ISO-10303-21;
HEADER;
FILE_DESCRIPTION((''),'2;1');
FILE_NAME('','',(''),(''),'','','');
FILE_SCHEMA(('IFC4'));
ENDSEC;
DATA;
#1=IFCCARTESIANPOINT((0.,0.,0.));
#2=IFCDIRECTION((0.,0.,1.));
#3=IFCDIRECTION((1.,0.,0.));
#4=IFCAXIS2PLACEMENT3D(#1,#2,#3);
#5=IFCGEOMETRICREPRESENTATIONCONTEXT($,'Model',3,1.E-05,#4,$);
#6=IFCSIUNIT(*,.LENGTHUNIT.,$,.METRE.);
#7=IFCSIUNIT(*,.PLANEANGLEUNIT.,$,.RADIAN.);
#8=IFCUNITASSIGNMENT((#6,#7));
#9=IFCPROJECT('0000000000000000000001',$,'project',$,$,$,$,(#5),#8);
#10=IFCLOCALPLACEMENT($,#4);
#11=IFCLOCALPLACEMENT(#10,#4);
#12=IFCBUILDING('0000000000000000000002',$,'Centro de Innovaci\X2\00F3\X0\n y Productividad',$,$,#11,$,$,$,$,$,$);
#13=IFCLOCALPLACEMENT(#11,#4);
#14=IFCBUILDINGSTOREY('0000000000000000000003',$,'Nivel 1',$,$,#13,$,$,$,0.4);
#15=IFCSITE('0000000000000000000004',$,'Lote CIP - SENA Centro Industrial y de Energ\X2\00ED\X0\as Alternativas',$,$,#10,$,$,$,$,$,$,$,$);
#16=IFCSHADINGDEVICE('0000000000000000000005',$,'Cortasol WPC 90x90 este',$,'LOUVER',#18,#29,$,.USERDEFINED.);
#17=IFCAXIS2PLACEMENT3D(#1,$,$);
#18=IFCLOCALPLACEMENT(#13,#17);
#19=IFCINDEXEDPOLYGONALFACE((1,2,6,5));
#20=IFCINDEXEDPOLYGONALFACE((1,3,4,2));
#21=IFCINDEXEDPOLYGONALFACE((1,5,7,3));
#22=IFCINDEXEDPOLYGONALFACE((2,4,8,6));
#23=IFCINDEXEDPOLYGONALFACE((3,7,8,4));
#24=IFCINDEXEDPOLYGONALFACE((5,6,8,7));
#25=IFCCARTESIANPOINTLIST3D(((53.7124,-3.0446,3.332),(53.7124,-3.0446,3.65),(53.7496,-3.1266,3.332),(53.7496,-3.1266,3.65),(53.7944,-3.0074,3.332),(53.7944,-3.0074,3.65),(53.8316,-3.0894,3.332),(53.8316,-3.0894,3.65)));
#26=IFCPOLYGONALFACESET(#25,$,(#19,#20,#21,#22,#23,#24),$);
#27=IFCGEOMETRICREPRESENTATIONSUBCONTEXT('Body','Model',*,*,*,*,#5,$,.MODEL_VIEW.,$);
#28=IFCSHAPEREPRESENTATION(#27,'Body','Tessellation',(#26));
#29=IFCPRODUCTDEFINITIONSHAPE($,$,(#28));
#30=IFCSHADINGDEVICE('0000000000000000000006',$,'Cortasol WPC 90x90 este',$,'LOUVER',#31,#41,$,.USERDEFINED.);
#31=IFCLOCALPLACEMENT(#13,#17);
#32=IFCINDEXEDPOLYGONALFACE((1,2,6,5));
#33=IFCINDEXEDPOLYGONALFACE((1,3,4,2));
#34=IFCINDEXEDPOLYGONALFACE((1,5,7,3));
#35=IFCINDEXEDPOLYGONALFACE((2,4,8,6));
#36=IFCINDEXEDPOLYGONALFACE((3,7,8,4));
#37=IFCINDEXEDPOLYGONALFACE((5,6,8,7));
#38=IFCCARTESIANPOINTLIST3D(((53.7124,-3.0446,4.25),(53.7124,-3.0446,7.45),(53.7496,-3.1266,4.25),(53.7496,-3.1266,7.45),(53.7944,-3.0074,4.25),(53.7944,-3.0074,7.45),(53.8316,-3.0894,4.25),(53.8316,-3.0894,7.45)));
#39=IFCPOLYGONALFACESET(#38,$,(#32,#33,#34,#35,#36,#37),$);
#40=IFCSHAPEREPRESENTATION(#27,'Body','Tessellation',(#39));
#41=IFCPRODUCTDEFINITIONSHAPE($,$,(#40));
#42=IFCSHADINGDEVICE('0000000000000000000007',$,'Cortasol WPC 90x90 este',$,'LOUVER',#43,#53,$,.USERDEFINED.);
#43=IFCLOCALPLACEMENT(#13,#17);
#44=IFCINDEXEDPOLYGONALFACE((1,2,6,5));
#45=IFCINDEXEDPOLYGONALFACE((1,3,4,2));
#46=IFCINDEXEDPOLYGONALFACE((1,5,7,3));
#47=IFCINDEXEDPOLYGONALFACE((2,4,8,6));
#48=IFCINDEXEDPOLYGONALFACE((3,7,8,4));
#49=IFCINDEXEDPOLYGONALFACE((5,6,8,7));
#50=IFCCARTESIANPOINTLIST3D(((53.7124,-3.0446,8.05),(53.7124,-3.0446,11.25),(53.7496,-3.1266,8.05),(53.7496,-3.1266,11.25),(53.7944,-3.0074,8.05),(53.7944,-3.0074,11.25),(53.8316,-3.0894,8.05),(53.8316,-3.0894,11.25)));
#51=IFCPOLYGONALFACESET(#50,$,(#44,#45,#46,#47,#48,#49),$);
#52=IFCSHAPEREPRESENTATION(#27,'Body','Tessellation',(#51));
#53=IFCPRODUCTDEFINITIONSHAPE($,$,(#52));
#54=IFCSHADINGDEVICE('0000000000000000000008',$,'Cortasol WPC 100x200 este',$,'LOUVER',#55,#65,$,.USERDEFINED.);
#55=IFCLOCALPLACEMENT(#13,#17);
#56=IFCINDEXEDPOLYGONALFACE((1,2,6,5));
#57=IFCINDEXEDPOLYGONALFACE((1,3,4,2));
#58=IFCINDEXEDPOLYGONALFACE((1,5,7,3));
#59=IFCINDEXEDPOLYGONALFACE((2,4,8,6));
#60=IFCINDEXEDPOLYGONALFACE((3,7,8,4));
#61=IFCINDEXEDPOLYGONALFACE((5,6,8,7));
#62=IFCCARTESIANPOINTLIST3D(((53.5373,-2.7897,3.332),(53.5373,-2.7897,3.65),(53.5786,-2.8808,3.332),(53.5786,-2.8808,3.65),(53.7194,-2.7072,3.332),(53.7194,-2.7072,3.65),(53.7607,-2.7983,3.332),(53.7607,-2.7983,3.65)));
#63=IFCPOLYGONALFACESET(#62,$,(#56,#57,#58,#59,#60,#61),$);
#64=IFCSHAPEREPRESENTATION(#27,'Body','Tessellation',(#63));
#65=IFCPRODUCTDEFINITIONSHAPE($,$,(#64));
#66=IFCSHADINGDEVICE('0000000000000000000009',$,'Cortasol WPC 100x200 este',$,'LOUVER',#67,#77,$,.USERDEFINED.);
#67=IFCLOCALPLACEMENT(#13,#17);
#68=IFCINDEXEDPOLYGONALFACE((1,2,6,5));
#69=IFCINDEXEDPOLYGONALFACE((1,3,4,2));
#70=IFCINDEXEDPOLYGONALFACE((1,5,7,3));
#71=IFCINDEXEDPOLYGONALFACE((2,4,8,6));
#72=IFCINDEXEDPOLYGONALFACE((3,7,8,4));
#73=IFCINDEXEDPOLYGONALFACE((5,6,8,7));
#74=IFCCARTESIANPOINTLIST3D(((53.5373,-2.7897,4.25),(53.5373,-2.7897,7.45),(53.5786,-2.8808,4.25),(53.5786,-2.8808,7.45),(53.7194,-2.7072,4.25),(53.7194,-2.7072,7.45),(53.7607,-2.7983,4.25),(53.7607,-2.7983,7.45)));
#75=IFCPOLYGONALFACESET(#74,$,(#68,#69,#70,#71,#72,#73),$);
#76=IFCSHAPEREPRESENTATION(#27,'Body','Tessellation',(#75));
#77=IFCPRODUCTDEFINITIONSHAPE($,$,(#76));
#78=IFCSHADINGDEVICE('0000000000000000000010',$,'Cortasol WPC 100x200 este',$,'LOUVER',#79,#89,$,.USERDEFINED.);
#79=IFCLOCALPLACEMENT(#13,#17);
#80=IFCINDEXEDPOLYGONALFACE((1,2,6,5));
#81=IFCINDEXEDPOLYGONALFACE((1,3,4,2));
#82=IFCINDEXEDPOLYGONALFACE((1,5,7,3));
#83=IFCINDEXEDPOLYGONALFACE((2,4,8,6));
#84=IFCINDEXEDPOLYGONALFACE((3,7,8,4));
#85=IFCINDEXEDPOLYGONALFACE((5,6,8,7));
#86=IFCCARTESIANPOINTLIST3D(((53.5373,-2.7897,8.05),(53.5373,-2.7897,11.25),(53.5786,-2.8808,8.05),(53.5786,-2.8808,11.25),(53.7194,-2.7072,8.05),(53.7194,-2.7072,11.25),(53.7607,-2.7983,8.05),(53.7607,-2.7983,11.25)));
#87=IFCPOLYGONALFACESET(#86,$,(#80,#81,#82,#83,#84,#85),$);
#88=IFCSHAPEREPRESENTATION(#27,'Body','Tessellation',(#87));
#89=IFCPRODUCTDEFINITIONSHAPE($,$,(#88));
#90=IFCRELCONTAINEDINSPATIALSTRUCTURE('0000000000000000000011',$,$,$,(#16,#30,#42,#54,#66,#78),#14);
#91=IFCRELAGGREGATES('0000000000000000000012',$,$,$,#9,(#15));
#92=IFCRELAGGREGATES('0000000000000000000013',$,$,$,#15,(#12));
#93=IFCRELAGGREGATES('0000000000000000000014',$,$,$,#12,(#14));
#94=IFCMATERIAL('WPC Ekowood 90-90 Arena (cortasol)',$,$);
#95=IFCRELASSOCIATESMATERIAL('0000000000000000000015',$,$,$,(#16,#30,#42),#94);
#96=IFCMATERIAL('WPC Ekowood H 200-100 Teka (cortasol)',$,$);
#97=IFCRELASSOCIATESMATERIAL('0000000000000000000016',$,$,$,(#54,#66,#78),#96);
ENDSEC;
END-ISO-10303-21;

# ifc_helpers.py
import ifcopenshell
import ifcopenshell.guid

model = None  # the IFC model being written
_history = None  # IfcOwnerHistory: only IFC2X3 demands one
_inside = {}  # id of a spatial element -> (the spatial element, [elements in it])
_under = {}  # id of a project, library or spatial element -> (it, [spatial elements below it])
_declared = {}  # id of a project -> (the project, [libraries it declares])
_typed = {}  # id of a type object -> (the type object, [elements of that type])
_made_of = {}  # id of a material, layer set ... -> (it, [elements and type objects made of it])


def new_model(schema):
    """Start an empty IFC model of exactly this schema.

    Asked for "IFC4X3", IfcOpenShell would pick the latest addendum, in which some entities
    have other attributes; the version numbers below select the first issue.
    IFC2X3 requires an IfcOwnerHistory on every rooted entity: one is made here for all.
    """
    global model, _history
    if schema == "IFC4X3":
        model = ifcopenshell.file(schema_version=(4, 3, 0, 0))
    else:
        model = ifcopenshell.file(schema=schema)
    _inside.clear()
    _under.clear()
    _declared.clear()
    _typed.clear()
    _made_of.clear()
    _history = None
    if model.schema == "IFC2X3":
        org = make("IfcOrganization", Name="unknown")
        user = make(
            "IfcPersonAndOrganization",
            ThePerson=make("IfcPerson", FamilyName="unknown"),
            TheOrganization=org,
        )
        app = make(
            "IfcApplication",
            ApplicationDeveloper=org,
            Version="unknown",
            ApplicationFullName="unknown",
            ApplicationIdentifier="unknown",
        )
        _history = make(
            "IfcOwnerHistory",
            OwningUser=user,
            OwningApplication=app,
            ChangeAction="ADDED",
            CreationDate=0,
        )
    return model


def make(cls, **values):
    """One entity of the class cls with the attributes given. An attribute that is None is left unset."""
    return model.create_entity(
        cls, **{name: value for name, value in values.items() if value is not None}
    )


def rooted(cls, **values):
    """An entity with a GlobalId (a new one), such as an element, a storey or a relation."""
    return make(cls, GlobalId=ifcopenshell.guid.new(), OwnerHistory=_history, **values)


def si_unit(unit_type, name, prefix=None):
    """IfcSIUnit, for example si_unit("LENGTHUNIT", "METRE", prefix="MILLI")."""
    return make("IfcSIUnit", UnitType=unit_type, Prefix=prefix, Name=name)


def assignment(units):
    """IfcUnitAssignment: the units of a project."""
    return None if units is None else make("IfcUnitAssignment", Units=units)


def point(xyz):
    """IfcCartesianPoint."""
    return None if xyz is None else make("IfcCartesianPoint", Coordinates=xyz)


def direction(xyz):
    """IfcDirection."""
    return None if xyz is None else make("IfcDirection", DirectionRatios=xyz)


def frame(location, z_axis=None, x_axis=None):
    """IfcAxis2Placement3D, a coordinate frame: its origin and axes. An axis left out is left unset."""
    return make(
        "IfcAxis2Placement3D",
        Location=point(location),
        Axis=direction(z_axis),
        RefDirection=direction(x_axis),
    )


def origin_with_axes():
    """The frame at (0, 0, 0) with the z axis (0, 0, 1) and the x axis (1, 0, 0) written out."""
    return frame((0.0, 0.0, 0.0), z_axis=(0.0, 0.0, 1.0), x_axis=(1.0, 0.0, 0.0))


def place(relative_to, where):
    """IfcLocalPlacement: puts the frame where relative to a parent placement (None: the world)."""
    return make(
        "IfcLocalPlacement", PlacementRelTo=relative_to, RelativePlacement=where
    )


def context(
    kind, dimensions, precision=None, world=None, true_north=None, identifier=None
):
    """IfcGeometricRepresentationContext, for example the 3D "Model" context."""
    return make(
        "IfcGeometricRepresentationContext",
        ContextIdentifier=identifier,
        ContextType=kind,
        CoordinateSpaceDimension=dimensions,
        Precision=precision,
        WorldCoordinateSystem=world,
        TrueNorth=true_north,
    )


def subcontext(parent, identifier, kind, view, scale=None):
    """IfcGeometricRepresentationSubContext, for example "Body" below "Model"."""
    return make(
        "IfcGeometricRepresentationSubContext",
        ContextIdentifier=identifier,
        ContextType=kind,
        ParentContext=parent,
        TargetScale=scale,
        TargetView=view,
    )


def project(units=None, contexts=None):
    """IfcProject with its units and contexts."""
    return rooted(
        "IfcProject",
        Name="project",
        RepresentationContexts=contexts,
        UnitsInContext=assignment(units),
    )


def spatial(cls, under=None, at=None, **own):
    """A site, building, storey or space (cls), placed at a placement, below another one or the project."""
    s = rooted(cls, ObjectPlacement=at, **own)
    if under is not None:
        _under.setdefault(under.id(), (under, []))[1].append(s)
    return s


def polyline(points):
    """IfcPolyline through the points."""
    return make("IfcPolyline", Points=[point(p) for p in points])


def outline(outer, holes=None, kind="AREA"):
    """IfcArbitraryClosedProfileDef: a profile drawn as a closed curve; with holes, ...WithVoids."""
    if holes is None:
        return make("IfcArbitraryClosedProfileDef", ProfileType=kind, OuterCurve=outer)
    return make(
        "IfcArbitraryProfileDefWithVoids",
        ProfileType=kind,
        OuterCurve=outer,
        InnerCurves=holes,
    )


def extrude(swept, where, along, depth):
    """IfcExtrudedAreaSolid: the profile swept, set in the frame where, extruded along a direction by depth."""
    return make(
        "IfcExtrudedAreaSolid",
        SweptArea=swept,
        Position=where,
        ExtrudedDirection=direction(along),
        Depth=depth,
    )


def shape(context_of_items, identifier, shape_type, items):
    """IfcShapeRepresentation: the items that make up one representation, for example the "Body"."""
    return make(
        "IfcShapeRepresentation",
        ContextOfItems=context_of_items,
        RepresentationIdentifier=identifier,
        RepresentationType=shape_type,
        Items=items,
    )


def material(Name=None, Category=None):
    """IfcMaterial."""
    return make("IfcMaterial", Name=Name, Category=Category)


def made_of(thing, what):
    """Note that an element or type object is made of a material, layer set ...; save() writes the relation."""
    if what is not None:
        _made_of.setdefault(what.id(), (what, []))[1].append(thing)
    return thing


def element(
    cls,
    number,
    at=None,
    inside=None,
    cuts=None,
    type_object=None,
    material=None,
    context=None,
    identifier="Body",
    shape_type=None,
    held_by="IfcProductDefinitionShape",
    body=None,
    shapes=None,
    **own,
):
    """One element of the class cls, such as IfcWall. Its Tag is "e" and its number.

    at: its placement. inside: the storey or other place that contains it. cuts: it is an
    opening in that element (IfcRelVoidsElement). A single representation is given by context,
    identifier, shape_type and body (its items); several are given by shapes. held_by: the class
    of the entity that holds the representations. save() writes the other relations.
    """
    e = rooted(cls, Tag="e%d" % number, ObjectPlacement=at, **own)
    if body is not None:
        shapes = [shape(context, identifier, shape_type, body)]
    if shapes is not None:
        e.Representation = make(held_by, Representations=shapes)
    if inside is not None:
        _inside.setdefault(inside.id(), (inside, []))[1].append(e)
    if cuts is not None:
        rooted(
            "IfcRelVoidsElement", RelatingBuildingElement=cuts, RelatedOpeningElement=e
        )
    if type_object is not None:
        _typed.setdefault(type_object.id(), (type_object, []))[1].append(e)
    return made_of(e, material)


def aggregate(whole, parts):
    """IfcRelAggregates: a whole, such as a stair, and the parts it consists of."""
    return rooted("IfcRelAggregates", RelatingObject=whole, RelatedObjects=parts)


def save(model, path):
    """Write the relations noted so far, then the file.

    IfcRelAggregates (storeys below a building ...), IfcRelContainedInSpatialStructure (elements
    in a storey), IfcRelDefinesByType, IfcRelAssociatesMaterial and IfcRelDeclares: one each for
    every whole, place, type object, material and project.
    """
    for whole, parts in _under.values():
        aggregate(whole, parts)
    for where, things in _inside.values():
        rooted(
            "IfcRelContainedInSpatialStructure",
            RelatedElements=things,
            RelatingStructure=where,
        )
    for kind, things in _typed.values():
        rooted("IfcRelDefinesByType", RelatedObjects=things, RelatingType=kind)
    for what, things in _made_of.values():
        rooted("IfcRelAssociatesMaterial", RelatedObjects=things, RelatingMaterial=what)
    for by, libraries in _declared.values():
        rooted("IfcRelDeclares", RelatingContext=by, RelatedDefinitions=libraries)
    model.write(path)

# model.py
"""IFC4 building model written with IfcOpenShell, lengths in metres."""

from ifc_helpers import new_model, si_unit, frame, origin_with_axes, place, context, subcontext, project, spatial, polyline, outline, extrude, material, element, save


model = new_model("IFC4")

# Units and contexts
model_context = context("Model", 3, precision=1e-05, world=origin_with_axes())
body_context = subcontext(model_context, "Body", "Model", "MODEL_VIEW")
ifc_project = project(units=[si_unit("LENGTHUNIT", "METRE"), si_unit("PLANEANGLEUNIT", "RADIAN")], contexts=[model_context])

# Site, building, storey
site_placement = place(None, origin_with_axes())
site = spatial("IfcSite", under=ifc_project, at=site_placement, Name="Lote CIP - SENA Centro Industrial y de Energías Alternativas")
building_placement = place(site_placement, origin_with_axes())
building = spatial("IfcBuilding", under=site, at=building_placement, Name="Centro de Innovación y Productividad")
storey_placement = place(building_placement, origin_with_axes())
storey = spatial("IfcBuildingStorey", under=building, at=storey_placement, Name="Nivel 1", Elevation=0.4)

# Shading devices
ifc_material_1 = material(Name="WPC Ekowood H 200-100 Teka (cortasol)")
ifc_material_2 = material(Name="WPC Ekowood 90-90 Arena (cortasol)")
shading_device_1_placement = place(storey_placement, origin_with_axes())
element("IfcShadingDevice", 1, at=shading_device_1_placement, inside=storey, material=ifc_material_2, Name="Cortasol WPC 90x90 este", ObjectType="LOUVER", PredefinedType="USERDEFINED", context=body_context, shape_type="SweptSolid", body=[
    extrude(outline(polyline([(53.7124, -3.0446), (53.7944, -3.0074), (53.8316, -3.0894), (53.7496, -3.1266), (53.7124, -3.0446)])), frame((0.0, 0.0, 3.332)), (0.0, 0.0, 1.0), 0.318),
])
shading_device_2_placement = place(storey_placement, origin_with_axes())
element("IfcShadingDevice", 2, at=shading_device_2_placement, inside=storey, material=ifc_material_2, Name="Cortasol WPC 90x90 este", ObjectType="LOUVER", PredefinedType="USERDEFINED", context=body_context, shape_type="SweptSolid", body=[
    extrude(outline(polyline([(53.7124, -3.0446), (53.7944, -3.0074), (53.8316, -3.0894), (53.7496, -3.1266), (53.7124, -3.0446)])), frame((0.0, 0.0, 4.25)), (0.0, 0.0, 1.0), 3.2),
])
shading_device_3_placement = place(storey_placement, origin_with_axes())
element("IfcShadingDevice", 3, at=shading_device_3_placement, inside=storey, material=ifc_material_2, Name="Cortasol WPC 90x90 este", ObjectType="LOUVER", PredefinedType="USERDEFINED", context=body_context, shape_type="SweptSolid", body=[
    extrude(outline(polyline([(53.7124, -3.0446), (53.7944, -3.0074), (53.8316, -3.0894), (53.7496, -3.1266), (53.7124, -3.0446)])), frame((0.0, 0.0, 8.05)), (0.0, 0.0, 1.0), 3.2),
])
shading_device_4_placement = place(storey_placement, origin_with_axes())
element("IfcShadingDevice", 4, at=shading_device_4_placement, inside=storey, material=ifc_material_1, Name="Cortasol WPC 100x200 este", ObjectType="LOUVER", PredefinedType="USERDEFINED", context=body_context, shape_type="SweptSolid", body=[
    extrude(outline(polyline([(53.5373, -2.7897), (53.7194, -2.7072), (53.7607, -2.7983), (53.5786, -2.8808), (53.5373, -2.7897)])), frame((0.0, 0.0, 3.332)), (0.0, 0.0, 1.0), 0.318),
])
shading_device_5_placement = place(storey_placement, origin_with_axes())
element("IfcShadingDevice", 5, at=shading_device_5_placement, inside=storey, material=ifc_material_1, Name="Cortasol WPC 100x200 este", ObjectType="LOUVER", PredefinedType="USERDEFINED", context=body_context, shape_type="SweptSolid", body=[
    extrude(outline(polyline([(53.5373, -2.7897), (53.7194, -2.7072), (53.7607, -2.7983), (53.5786, -2.8808), (53.5373, -2.7897)])), frame((0.0, 0.0, 4.25)), (0.0, 0.0, 1.0), 3.2),
])
shading_device_6_placement = place(storey_placement, origin_with_axes())
element("IfcShadingDevice", 6, at=shading_device_6_placement, inside=storey, material=ifc_material_1, Name="Cortasol WPC 100x200 este", ObjectType="LOUVER", PredefinedType="USERDEFINED", context=body_context, shape_type="SweptSolid", body=[
    extrude(outline(polyline([(53.5373, -2.7897), (53.7194, -2.7072), (53.7607, -2.7983), (53.5786, -2.8808), (53.5373, -2.7897)])), frame((0.0, 0.0, 8.05)), (0.0, 0.0, 1.0), 3.2),
])

save(model, "model.ifc")
